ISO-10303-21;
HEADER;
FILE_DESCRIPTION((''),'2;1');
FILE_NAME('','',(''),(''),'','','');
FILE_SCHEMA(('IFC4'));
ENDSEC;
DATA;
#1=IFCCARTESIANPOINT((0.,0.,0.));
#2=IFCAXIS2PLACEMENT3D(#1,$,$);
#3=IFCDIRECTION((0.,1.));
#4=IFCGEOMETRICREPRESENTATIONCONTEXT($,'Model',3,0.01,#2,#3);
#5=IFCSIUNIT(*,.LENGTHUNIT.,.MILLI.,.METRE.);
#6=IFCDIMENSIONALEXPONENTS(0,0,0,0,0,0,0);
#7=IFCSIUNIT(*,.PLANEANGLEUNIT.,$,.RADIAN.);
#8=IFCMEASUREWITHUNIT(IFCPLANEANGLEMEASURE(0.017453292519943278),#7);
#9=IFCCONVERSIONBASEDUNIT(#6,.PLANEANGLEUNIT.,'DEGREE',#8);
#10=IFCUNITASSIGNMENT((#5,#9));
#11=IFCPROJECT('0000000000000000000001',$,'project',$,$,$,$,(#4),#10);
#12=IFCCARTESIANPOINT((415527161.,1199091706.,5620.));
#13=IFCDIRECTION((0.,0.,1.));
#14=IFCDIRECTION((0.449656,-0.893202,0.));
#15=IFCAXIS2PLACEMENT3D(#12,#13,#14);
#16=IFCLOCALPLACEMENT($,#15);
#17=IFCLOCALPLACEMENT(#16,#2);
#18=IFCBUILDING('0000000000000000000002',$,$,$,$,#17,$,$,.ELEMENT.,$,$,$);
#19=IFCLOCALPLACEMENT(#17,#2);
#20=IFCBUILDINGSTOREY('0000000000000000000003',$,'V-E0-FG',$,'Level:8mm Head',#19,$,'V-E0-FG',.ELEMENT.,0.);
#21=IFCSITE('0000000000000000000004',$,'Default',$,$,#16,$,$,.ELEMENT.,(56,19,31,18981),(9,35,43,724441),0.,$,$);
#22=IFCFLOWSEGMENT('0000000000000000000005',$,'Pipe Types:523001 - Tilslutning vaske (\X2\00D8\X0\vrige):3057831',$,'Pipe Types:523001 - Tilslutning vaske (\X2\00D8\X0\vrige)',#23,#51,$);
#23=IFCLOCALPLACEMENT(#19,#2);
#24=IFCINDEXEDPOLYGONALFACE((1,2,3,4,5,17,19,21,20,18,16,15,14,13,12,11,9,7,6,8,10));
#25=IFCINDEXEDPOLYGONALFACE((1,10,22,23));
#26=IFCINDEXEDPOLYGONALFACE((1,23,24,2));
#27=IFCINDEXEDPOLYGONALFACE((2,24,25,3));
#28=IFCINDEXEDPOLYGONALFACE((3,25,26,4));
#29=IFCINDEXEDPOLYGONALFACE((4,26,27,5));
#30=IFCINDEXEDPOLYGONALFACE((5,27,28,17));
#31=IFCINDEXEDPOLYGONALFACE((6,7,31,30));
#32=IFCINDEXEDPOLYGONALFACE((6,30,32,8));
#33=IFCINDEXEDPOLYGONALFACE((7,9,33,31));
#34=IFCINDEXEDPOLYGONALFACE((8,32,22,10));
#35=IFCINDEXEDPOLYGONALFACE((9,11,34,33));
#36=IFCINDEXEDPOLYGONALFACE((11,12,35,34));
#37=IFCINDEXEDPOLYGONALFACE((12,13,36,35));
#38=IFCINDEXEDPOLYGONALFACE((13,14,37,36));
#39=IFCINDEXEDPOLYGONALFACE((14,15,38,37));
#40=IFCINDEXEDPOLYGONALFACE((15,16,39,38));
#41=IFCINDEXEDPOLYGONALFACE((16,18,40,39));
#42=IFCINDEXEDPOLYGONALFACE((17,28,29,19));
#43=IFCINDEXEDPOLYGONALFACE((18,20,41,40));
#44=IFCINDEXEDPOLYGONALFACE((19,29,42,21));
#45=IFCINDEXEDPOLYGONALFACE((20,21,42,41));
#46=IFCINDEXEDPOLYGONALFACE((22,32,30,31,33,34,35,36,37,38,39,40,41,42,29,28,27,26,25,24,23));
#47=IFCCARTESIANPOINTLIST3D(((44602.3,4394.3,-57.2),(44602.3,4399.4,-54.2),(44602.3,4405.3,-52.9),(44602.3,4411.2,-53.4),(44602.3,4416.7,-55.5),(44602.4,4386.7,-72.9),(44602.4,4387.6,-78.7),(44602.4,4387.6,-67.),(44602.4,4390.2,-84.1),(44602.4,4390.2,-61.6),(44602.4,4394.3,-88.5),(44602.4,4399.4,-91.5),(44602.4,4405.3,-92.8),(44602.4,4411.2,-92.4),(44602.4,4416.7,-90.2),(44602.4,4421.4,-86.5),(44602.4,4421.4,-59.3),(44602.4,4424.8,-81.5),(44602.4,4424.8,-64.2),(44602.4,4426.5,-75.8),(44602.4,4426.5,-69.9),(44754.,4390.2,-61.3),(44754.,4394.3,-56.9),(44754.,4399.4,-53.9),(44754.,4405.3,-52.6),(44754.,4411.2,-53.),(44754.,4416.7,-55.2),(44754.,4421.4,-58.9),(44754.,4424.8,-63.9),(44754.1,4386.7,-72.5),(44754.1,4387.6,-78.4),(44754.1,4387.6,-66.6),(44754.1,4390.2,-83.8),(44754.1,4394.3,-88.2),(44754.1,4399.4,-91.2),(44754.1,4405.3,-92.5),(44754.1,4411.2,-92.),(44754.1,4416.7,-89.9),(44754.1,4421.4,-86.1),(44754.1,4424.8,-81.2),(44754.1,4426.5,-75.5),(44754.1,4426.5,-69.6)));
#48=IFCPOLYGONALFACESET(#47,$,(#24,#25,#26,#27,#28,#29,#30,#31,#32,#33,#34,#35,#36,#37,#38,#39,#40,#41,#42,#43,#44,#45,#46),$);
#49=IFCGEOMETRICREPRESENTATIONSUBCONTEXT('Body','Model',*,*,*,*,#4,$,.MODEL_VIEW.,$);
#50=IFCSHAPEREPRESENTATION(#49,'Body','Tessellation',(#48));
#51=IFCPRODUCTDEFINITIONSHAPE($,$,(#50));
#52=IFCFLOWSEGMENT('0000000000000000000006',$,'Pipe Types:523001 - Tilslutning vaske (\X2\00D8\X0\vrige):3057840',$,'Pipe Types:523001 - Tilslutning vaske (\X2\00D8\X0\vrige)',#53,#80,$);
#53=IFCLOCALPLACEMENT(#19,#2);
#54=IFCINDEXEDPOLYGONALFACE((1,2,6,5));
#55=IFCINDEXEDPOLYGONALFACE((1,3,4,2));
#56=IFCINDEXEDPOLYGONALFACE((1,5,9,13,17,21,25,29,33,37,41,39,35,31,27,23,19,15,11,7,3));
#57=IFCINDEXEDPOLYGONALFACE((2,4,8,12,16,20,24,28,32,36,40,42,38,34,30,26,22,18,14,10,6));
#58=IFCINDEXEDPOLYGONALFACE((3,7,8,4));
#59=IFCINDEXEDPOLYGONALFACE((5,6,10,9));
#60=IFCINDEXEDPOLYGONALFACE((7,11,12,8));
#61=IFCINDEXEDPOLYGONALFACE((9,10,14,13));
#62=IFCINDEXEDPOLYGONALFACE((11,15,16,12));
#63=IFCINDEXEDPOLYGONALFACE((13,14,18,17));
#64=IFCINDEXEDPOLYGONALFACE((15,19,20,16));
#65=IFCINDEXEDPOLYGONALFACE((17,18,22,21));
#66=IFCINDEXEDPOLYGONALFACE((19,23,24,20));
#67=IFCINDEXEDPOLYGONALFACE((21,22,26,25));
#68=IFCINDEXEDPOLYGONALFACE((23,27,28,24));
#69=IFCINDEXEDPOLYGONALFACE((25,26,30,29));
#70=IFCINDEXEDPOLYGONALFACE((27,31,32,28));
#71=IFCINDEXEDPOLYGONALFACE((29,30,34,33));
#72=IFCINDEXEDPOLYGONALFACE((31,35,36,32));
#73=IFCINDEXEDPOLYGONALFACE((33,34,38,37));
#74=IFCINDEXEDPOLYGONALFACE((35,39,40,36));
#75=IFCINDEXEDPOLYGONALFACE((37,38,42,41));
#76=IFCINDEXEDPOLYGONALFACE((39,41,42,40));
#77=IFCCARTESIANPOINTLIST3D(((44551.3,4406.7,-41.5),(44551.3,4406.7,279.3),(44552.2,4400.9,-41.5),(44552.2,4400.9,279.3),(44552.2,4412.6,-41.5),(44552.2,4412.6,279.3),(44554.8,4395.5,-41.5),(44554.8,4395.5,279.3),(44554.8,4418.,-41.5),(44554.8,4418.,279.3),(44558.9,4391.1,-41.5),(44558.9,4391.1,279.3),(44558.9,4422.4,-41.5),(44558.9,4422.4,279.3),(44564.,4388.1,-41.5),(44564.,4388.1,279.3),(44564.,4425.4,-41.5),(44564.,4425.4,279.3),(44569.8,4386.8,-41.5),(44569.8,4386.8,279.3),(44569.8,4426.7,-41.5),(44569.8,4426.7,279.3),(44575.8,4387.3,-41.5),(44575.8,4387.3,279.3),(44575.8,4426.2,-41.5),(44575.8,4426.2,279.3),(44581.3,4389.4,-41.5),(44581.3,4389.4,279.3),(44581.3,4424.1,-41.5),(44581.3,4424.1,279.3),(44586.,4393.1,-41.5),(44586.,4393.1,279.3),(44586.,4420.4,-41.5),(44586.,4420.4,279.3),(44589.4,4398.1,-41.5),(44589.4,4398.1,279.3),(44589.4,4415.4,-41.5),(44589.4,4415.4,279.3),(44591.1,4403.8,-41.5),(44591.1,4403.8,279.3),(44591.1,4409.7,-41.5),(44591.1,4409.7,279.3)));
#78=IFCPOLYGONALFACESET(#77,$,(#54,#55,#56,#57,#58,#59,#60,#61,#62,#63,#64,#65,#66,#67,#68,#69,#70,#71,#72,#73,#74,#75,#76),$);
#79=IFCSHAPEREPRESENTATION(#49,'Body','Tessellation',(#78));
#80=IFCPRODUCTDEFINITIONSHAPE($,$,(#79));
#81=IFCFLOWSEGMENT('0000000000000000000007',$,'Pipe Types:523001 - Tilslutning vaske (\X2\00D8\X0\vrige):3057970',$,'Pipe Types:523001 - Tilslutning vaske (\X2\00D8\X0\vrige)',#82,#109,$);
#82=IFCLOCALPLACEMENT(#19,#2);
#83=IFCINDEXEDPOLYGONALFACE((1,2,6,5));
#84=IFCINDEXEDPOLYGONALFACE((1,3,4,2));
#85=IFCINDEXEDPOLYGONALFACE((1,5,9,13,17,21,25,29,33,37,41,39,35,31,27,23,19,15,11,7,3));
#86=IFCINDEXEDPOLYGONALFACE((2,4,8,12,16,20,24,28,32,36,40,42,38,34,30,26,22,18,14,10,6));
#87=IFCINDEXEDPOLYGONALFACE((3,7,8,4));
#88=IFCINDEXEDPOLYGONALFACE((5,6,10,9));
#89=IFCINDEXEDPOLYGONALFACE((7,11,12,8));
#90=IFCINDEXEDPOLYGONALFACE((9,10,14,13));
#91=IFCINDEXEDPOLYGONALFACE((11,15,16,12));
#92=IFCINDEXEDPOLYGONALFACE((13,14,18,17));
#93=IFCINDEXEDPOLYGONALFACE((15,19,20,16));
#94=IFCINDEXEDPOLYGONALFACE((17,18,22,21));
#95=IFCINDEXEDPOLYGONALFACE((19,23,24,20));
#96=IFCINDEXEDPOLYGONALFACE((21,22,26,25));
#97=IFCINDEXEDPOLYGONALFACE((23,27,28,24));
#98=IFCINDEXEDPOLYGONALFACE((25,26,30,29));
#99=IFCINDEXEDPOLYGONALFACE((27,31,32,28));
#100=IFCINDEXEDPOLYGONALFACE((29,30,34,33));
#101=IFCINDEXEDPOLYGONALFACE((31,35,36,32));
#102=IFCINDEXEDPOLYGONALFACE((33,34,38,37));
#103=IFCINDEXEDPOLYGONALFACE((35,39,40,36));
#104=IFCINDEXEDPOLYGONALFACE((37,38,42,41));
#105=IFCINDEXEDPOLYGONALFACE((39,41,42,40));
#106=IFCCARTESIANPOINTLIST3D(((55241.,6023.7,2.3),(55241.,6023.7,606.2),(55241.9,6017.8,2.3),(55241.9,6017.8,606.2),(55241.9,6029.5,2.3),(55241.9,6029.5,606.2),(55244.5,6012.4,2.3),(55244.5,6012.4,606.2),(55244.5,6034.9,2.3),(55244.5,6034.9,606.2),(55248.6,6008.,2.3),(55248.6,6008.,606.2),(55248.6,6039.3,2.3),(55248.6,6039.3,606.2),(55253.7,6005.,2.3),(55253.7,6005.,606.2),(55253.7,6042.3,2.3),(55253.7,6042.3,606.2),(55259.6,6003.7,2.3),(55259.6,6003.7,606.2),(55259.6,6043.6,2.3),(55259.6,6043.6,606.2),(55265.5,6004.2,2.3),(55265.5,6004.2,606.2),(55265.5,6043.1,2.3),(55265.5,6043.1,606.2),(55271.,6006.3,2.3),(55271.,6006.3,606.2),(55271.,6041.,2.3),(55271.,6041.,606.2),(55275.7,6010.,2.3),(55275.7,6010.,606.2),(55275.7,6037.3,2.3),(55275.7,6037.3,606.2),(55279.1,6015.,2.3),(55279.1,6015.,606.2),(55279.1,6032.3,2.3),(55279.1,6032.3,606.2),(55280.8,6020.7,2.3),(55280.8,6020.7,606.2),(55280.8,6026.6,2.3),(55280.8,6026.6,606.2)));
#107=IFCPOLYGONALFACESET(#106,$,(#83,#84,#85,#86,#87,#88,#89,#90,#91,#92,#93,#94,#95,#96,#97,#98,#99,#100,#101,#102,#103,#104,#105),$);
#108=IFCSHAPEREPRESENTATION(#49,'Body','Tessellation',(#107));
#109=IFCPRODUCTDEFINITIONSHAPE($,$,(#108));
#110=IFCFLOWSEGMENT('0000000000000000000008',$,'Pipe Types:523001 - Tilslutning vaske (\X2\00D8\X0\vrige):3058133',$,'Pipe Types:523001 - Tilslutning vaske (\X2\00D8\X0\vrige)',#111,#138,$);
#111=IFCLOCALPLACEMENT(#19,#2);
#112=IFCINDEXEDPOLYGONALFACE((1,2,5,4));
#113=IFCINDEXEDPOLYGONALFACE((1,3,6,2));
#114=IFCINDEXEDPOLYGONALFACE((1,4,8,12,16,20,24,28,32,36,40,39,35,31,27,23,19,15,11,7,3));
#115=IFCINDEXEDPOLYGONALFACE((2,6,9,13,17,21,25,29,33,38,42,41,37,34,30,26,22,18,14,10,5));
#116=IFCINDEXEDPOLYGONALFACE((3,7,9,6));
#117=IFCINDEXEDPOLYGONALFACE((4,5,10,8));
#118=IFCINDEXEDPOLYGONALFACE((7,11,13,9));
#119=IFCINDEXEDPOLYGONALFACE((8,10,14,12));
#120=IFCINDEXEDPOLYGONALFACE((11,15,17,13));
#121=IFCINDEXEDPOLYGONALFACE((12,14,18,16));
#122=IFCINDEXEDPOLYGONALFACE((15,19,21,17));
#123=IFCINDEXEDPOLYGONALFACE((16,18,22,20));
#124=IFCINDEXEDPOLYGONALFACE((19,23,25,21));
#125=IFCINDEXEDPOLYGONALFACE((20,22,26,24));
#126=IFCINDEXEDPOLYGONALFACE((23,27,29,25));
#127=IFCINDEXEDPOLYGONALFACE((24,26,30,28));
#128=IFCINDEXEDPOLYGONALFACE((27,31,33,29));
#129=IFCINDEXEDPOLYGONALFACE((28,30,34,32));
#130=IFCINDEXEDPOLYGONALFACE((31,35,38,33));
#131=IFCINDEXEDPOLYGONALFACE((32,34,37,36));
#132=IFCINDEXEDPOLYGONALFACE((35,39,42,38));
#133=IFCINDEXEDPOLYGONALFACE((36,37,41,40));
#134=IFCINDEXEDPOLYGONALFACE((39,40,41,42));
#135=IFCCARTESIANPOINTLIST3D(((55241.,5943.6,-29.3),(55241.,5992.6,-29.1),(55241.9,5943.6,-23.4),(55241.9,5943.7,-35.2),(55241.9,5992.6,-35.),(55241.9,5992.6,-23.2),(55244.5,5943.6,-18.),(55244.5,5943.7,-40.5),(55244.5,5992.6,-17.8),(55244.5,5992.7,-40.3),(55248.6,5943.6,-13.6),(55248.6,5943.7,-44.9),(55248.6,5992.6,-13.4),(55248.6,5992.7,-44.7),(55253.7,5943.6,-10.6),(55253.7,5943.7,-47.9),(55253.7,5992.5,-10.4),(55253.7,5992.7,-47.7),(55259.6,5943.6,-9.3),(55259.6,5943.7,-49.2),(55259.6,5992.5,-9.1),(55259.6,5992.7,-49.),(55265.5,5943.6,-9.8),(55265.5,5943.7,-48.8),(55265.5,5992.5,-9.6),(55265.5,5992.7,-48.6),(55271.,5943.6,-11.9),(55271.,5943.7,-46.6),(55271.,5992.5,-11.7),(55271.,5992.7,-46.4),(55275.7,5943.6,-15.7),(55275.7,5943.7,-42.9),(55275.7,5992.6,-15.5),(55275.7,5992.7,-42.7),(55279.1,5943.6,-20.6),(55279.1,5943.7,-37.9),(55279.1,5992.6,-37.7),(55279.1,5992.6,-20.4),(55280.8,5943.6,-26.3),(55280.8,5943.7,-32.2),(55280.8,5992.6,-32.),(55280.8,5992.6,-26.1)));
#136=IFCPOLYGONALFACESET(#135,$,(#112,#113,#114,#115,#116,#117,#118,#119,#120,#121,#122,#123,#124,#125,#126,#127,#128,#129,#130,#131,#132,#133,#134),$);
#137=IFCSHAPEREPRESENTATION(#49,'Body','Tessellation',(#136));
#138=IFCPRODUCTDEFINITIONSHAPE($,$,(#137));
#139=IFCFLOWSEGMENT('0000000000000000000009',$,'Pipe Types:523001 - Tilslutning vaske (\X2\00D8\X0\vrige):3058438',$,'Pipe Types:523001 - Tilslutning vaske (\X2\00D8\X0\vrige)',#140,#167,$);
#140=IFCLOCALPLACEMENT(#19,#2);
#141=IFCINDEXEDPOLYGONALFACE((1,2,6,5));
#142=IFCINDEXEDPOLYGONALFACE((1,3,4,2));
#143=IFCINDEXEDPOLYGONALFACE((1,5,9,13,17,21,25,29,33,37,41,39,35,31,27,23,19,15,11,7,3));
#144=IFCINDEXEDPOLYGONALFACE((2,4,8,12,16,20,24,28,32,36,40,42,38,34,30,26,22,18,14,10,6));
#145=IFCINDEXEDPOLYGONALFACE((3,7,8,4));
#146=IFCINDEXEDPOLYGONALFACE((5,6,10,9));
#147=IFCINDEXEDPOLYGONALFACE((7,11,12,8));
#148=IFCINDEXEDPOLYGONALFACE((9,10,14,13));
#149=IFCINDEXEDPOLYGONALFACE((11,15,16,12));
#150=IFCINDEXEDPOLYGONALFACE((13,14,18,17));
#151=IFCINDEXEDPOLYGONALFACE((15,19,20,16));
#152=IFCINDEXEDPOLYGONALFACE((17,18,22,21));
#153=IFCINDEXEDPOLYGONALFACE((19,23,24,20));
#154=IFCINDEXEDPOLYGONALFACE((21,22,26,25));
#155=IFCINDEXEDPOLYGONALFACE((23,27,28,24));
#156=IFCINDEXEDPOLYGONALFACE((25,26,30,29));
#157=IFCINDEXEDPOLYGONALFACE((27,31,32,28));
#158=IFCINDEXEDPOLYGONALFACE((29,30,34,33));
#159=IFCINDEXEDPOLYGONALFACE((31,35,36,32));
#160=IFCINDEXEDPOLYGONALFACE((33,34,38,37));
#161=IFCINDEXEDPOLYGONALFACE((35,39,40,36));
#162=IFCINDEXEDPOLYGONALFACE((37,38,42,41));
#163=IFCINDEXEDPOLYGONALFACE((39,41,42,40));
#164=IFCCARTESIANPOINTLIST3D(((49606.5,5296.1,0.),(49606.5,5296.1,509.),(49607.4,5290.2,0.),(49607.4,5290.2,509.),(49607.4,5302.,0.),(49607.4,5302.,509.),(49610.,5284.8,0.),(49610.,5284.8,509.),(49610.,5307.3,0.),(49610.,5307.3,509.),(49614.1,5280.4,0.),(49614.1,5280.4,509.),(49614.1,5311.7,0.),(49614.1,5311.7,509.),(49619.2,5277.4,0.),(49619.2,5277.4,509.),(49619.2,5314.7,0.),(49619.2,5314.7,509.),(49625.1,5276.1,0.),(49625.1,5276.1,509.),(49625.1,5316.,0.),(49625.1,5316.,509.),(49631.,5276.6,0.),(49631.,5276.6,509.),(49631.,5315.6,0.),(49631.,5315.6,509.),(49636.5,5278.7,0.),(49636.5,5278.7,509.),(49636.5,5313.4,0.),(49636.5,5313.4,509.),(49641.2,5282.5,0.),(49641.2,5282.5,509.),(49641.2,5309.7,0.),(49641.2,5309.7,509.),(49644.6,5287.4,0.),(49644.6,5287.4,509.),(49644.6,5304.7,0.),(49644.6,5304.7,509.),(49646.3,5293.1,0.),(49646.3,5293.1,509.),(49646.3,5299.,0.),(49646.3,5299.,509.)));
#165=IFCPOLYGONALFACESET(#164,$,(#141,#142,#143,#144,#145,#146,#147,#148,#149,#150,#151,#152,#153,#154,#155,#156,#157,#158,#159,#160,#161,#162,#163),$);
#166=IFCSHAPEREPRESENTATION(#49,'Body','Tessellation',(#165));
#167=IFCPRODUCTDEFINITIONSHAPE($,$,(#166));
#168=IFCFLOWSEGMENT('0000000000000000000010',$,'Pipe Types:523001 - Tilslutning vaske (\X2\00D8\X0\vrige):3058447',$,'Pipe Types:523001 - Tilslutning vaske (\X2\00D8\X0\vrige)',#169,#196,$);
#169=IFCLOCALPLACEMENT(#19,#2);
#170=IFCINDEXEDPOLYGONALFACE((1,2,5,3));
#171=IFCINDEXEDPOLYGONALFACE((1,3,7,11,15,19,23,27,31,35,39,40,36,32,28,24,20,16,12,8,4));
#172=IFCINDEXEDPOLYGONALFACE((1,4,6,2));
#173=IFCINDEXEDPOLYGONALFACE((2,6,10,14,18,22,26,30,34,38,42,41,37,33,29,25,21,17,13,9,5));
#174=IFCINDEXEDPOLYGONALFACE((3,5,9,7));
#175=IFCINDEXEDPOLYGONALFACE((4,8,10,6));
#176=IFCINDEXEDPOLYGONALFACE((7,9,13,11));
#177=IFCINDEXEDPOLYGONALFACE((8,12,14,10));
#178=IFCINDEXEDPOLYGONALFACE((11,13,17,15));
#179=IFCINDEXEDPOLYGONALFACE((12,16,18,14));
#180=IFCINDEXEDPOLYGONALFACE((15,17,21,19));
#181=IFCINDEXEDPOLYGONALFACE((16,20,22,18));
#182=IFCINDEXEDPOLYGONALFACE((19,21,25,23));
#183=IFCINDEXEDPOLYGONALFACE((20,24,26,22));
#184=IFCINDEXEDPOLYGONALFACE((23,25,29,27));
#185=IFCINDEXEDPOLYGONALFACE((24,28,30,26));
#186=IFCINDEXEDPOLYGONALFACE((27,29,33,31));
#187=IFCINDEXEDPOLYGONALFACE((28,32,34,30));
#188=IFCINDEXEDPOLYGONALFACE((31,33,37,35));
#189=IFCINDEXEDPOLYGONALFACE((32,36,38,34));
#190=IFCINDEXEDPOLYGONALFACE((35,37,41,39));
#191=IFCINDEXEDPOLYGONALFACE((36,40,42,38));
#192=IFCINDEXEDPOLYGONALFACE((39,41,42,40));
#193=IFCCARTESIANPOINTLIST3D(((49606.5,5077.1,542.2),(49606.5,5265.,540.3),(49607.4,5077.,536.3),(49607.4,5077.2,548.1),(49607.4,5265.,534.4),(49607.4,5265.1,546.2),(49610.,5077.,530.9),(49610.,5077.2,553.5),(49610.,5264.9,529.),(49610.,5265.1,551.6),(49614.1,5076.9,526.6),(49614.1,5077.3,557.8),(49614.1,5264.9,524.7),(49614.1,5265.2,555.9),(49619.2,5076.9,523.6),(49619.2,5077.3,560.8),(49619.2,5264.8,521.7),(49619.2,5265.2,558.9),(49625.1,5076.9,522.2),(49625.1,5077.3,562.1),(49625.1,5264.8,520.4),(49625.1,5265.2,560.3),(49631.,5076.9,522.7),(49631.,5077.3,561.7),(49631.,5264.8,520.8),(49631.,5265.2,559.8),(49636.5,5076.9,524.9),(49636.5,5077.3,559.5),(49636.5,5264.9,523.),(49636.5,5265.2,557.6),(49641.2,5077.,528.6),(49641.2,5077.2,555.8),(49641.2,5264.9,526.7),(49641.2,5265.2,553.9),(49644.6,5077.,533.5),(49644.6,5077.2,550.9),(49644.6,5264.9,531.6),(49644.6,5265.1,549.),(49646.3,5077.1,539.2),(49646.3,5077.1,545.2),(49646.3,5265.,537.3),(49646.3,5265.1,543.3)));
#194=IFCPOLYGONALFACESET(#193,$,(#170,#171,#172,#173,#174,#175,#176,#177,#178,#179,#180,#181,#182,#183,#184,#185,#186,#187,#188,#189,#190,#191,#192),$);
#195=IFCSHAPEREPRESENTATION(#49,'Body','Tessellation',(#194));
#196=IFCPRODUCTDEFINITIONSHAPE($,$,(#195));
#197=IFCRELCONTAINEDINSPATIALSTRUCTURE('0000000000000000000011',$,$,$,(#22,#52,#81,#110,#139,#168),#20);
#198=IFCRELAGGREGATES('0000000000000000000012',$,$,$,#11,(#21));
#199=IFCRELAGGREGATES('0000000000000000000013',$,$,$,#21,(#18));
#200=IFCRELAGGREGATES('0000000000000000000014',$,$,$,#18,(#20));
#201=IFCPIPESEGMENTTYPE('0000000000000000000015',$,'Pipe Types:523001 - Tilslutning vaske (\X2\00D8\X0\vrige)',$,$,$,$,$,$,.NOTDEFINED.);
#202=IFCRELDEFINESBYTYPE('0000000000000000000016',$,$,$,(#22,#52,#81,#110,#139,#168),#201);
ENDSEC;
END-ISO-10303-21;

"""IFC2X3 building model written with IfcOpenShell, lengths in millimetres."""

from ifc_helpers import new_model, entity, si_unit, converted_unit, direction, frame, frame_2d, origin, origin_2d_with_axis, place, context, subcontext, project, spatial, circle, extrude, type_object, element, save


model = new_model("IFC2X3")

# Units and contexts
model_context = context("Model", 3, precision=0.01, world=origin(), true_north=direction((0.0, 1.0)))
body_context = subcontext(model_context, "Body", "Model", "MODEL_VIEW")
ifc_project = project(units=[si_unit("LENGTHUNIT", "METRE", prefix="MILLI"), converted_unit("PLANEANGLEUNIT", "DEGREE", entity("IfcPlaneAngleMeasure", 0.017453292519943278), si_unit("PLANEANGLEUNIT", "RADIAN"), dimensions=[0, 0, 0, 0, 0, 0, 0])], contexts=[model_context])

# Site, building, storey
site_placement = place(None, frame((415527161.0, 1199091706.0, 5620.0), z_axis=(0.0, 0.0, 1.0), x_axis=(0.449656, -0.893202, 0.0)))
site = spatial("IfcSite", under=ifc_project, at=site_placement, Name="Default", CompositionType="ELEMENT", RefLatitude=(56, 19, 31, 18981), RefLongitude=(9, 35, 43, 724441), RefElevation=0.0)
building_placement = place(site_placement, origin())
building = spatial("IfcBuilding", under=site, at=building_placement, CompositionType="ELEMENT")
storey_placement = place(building_placement, origin())
storey = spatial("IfcBuildingStorey", under=building, at=storey_placement, Name="V-E0-FG", ObjectType="Level:8mm Head", LongName="V-E0-FG", CompositionType="ELEMENT", Elevation=0.0)

# Flow segments
pipe_segment_type_1 = type_object("IfcPipeSegmentType", Name="Pipe Types:523001 - Tilslutning vaske (Øvrige)", PredefinedType="NOTDEFINED")
flow_segment_1_placement = place(storey_placement, origin())
element("IfcFlowSegment", 1, at=flow_segment_1_placement, inside=storey, type_object=pipe_segment_type_1, Name="Pipe Types:523001 - Tilslutning vaske (Øvrige):3057831", ObjectType="Pipe Types:523001 - Tilslutning vaske (Øvrige)", context=body_context, shape_type="SweptSolid", body=[
    extrude(circle(Radius=20.0, at=frame_2d((0.0, 0.0), x_axis=(1.0, 0.0))), frame((44602.4, 4406.7, -72.9), z_axis=(0.999998, 0.0, 0.002046), x_axis=(0.0, -1.0, 0.0)), (0.0, 0.0, 1.0), 151.7),
])
flow_segment_2_placement = place(storey_placement, origin())
element("IfcFlowSegment", 2, at=flow_segment_2_placement, inside=storey, type_object=pipe_segment_type_1, Name="Pipe Types:523001 - Tilslutning vaske (Øvrige):3057840", ObjectType="Pipe Types:523001 - Tilslutning vaske (Øvrige)", context=body_context, shape_type="SweptSolid", body=[
    extrude(circle(Radius=20.0, at=origin_2d_with_axis()), frame((44571.3, 4406.7, -41.5), z_axis=(0.0, 0.0, 1.0), x_axis=(-1.0, 0.0, 0.0)), (0.0, 0.0, 1.0), 320.8),
])
flow_segment_3_placement = place(storey_placement, origin())
element("IfcFlowSegment", 3, at=flow_segment_3_placement, inside=storey, type_object=pipe_segment_type_1, Name="Pipe Types:523001 - Tilslutning vaske (Øvrige):3057970", ObjectType="Pipe Types:523001 - Tilslutning vaske (Øvrige)", context=body_context, shape_type="SweptSolid", body=[
    extrude(circle(Radius=20.0, at=origin_2d_with_axis()), frame((55261.0, 6023.7, 2.3), z_axis=(0.0, 0.0, 1.0), x_axis=(-1.0, 0.0, 0.0)), (0.0, 0.0, 1.0), 603.9),
])
flow_segment_4_placement = place(storey_placement, origin())
element("IfcFlowSegment", 4, at=flow_segment_4_placement, inside=storey, type_object=pipe_segment_type_1, Name="Pipe Types:523001 - Tilslutning vaske (Øvrige):3058133", ObjectType="Pipe Types:523001 - Tilslutning vaske (Øvrige)", context=body_context, shape_type="SweptSolid", body=[
    extrude(circle(Radius=20.0, at=frame_2d((0.0, 0.0), x_axis=(1.0, 0.0))), frame((55261.0, 5943.6, -29.3), z_axis=(0.0, 0.999992, 0.004018), x_axis=(-1.0, 0.0, 0.0)), (0.0, 0.0, 1.0), 49.0),
])
flow_segment_5_placement = place(storey_placement, origin())
element("IfcFlowSegment", 5, at=flow_segment_5_placement, inside=storey, type_object=pipe_segment_type_1, Name="Pipe Types:523001 - Tilslutning vaske (Øvrige):3058438", ObjectType="Pipe Types:523001 - Tilslutning vaske (Øvrige)", context=body_context, shape_type="SweptSolid", body=[
    extrude(circle(Radius=20.0, at=origin_2d_with_axis()), frame((49626.5, 5296.1, 0.0), z_axis=(0.0, 0.0, 1.0), x_axis=(-1.0, 0.0, 0.0)), (0.0, 0.0, 1.0), 509.0),
])
flow_segment_6_placement = place(storey_placement, origin())
element("IfcFlowSegment", 6, at=flow_segment_6_placement, inside=storey, type_object=pipe_segment_type_1, Name="Pipe Types:523001 - Tilslutning vaske (Øvrige):3058447", ObjectType="Pipe Types:523001 - Tilslutning vaske (Øvrige)", context=body_context, shape_type="SweptSolid", body=[
    extrude(circle(Radius=20.0, at=origin_2d_with_axis()), frame((49626.5, 5077.1, 542.2), z_axis=(0.0, 0.99995, -0.01), x_axis=(-1.0, 0.0, 0.0)), (0.0, 0.0, 1.0), 187.9),
])

save(model, "model.ifc")
